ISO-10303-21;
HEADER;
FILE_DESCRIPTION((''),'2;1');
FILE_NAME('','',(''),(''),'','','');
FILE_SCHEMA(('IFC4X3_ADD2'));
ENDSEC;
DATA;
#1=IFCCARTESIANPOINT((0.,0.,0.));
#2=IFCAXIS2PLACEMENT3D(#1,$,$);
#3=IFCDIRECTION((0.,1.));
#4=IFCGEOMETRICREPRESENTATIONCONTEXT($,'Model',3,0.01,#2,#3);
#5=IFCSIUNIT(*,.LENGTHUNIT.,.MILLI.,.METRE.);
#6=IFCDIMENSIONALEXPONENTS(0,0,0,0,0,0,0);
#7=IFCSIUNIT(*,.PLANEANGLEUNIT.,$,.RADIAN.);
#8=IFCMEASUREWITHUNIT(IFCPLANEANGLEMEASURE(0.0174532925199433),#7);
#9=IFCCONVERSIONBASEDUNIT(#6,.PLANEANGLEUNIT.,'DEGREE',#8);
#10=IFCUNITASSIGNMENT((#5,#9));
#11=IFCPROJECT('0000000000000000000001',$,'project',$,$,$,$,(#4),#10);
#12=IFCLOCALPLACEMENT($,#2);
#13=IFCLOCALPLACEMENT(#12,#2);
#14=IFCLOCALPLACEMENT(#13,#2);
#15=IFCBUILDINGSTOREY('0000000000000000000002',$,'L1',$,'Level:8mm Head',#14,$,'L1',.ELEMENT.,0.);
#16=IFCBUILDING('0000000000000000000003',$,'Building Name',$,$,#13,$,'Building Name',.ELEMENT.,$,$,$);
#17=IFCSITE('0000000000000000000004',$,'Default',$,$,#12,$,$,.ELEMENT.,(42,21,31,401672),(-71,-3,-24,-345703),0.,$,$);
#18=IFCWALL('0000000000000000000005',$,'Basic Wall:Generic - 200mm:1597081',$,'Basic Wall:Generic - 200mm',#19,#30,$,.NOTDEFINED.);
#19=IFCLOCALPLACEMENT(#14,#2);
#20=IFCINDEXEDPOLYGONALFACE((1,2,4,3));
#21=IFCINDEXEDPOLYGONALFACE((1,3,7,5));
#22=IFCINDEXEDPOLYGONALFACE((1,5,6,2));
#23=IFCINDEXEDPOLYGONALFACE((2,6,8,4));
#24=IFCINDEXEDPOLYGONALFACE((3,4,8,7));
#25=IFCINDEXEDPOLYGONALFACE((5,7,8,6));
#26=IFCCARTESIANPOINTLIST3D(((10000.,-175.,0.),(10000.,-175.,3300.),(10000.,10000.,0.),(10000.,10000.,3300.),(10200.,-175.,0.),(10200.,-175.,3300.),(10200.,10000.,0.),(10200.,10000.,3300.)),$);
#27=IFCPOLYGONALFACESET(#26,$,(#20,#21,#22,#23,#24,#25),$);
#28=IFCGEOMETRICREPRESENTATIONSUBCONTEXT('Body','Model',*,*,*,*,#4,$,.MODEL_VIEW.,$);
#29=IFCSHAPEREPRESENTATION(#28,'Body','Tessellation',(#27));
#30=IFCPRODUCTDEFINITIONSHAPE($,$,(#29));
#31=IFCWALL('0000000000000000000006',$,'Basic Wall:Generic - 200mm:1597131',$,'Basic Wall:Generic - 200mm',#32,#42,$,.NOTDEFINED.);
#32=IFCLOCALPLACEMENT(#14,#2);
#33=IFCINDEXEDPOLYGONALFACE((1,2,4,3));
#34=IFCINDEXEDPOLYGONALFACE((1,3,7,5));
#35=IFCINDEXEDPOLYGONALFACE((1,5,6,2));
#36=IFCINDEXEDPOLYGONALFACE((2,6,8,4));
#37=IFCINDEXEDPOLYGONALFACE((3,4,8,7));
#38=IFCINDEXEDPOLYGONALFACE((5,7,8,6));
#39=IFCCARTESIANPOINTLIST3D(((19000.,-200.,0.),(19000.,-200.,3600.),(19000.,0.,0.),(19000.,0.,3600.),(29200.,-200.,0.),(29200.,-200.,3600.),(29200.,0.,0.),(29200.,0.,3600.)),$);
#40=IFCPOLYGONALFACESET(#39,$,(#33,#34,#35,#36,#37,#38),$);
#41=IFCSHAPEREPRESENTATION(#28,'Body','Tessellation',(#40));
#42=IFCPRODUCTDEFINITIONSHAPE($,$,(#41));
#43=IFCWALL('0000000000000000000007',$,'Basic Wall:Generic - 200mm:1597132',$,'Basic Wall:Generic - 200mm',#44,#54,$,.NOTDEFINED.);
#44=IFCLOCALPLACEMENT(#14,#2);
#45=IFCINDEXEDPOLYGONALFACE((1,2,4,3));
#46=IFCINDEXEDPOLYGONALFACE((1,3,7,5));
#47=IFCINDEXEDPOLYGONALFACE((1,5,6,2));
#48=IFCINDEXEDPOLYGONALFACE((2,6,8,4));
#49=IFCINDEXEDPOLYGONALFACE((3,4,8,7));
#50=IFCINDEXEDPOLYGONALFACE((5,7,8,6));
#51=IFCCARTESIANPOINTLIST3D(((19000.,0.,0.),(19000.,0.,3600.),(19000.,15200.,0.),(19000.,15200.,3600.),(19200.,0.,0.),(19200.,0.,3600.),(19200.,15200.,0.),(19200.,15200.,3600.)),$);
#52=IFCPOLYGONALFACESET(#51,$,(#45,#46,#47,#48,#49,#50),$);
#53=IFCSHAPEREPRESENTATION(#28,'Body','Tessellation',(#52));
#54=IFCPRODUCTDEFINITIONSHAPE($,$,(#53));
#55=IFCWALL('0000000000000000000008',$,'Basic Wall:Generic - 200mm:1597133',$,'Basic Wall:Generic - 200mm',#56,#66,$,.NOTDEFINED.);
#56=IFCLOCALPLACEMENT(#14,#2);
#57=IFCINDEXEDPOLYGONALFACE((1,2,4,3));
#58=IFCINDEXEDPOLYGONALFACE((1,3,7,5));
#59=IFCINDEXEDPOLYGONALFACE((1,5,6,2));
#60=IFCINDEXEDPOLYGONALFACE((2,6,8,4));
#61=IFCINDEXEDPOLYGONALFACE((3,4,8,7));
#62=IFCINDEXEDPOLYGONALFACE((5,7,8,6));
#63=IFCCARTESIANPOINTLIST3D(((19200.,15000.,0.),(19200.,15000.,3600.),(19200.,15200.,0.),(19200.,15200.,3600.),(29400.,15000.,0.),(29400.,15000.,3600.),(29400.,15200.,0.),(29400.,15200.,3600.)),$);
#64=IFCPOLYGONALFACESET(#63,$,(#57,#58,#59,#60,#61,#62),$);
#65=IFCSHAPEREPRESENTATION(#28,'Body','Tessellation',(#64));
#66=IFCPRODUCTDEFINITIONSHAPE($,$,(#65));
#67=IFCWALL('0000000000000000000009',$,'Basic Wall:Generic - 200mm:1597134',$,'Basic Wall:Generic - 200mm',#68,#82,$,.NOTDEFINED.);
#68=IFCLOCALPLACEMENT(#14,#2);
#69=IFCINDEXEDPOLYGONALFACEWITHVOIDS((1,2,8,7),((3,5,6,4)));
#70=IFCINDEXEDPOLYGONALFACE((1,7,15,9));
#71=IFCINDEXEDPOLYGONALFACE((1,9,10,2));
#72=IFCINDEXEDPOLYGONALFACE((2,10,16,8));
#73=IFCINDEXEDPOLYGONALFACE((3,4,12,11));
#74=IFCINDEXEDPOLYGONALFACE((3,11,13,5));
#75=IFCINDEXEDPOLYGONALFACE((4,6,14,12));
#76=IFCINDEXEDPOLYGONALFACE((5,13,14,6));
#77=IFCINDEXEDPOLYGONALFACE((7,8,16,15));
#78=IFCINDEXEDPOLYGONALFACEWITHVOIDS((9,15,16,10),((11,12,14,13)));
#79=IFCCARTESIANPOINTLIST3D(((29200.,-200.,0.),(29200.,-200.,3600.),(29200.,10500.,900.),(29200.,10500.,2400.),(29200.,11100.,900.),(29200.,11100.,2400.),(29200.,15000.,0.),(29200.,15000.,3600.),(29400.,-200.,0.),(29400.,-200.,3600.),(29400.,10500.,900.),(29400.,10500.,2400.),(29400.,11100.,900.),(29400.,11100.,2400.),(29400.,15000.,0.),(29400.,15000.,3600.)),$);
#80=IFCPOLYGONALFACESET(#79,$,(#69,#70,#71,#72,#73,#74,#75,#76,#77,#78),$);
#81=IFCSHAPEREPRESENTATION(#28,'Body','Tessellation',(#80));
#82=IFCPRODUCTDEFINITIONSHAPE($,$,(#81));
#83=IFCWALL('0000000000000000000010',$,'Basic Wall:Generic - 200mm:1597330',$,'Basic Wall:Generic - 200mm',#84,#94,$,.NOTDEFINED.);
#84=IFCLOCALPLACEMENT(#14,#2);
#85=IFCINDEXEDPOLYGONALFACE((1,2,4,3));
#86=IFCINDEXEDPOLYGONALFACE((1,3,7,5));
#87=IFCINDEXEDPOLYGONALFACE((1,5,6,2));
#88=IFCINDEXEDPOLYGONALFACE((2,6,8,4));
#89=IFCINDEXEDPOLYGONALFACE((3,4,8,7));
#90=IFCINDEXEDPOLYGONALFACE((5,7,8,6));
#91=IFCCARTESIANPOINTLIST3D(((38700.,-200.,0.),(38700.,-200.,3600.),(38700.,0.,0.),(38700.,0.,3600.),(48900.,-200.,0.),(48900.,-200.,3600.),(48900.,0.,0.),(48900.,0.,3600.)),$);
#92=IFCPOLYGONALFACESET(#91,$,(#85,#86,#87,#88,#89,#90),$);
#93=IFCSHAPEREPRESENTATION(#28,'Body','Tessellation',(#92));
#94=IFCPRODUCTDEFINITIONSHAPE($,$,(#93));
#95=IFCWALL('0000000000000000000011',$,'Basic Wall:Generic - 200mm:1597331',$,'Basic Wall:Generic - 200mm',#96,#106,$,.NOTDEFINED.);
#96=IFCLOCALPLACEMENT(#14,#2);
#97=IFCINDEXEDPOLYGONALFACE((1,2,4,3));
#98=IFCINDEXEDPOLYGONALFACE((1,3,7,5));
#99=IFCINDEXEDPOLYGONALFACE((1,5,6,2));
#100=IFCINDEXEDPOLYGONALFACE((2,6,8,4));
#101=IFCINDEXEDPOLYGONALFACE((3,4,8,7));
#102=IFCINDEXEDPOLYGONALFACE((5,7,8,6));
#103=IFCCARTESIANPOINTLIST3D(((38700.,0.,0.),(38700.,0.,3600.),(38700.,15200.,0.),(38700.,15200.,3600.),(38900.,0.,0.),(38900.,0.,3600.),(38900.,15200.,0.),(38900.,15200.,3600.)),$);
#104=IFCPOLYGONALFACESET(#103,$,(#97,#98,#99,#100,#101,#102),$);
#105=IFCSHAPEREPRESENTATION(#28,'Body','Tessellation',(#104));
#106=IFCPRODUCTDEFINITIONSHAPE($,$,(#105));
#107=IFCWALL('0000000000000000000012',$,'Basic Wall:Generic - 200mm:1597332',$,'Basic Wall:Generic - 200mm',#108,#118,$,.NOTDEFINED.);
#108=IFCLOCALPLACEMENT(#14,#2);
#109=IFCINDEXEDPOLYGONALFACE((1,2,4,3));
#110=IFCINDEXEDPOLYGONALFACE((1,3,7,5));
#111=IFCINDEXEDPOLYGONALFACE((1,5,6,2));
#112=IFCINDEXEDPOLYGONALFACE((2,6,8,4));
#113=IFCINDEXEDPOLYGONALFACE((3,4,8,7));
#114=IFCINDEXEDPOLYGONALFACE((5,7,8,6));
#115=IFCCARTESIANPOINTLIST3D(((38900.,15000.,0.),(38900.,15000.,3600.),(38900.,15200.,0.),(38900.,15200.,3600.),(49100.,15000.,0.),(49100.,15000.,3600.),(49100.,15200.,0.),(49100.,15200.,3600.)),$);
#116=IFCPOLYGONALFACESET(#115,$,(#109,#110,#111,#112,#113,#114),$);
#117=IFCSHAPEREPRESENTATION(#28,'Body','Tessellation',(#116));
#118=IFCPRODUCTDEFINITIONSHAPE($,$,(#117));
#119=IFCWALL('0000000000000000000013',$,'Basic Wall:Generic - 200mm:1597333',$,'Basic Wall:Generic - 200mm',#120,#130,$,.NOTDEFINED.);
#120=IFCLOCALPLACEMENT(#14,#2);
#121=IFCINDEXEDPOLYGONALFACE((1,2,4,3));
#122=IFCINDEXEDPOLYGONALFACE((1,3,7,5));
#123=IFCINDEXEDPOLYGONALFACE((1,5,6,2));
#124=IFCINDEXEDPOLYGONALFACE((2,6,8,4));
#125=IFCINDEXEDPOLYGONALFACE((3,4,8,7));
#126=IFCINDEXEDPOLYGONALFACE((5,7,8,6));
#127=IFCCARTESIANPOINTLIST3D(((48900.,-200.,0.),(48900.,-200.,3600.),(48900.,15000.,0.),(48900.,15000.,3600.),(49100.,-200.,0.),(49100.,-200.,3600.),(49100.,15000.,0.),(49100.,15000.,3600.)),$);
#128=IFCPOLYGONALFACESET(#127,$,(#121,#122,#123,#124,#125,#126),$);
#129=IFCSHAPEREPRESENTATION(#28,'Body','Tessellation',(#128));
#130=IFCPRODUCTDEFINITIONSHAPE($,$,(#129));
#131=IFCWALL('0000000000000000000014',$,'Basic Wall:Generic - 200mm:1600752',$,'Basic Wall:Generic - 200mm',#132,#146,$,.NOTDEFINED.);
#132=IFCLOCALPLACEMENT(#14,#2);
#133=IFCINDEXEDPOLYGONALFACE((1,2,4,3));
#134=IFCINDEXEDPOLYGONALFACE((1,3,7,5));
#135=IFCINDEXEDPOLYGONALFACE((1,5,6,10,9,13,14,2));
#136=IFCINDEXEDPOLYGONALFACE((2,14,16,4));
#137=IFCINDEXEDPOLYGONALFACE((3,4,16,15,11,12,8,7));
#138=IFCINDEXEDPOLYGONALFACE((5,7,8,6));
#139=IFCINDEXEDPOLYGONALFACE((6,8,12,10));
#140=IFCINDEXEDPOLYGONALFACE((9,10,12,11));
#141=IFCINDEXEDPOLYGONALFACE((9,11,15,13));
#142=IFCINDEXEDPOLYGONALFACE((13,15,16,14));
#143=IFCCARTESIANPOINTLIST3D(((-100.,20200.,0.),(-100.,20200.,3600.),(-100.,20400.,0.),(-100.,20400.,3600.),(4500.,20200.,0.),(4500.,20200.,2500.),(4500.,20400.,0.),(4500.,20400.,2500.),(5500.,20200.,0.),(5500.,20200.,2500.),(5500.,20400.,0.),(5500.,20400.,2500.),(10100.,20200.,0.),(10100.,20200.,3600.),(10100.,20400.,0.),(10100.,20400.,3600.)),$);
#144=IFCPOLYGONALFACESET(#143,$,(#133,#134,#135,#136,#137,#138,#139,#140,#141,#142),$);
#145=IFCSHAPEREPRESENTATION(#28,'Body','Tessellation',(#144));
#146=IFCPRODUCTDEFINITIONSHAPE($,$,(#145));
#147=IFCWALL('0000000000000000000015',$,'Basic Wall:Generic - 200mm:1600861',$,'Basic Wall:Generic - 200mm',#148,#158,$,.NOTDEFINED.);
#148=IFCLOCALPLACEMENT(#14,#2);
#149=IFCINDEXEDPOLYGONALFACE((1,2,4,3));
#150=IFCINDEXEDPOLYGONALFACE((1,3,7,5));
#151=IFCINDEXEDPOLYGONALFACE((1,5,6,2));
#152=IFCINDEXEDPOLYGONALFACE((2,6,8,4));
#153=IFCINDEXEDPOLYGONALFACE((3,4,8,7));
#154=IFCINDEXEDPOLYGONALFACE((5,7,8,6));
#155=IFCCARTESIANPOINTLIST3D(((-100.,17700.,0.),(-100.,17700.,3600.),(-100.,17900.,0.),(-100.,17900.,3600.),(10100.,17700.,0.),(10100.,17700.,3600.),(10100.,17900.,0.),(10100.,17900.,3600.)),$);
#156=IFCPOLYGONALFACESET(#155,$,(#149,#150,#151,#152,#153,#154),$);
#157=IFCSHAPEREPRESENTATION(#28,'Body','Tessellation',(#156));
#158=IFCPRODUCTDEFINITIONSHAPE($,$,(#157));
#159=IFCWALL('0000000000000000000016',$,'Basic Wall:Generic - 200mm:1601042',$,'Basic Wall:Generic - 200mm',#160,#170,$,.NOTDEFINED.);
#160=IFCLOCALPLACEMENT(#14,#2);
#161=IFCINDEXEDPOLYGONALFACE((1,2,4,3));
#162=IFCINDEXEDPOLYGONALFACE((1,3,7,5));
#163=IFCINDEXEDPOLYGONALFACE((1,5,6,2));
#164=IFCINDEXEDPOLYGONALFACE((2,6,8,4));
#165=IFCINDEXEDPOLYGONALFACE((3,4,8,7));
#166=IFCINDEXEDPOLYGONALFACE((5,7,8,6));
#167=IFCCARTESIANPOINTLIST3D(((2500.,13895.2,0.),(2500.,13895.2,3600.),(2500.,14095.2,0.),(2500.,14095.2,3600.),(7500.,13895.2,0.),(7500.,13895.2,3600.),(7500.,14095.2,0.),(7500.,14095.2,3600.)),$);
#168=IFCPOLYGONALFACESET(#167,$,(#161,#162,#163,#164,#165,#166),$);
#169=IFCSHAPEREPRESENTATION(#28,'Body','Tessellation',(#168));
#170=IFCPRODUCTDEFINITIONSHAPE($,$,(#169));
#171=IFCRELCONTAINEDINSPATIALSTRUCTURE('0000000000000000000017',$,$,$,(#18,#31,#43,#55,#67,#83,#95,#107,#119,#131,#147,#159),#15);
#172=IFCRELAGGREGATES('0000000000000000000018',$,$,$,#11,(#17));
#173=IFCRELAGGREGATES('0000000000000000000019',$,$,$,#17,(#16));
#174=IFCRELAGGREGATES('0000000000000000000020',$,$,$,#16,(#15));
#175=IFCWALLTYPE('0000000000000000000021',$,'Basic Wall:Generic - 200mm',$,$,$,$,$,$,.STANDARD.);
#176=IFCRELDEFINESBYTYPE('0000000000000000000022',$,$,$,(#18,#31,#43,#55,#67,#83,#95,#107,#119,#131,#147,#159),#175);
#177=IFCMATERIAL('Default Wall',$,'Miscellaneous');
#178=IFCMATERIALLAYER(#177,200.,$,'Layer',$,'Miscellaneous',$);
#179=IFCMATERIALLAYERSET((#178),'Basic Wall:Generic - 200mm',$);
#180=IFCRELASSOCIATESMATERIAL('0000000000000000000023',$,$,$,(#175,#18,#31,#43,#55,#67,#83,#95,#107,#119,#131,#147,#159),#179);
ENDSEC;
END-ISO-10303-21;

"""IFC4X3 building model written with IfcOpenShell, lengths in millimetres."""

from ifc_helpers import new_model, entity, si_unit, converted_unit, direction, frame, frame_2d, origin, origin_2d_with_axis, place, context, subcontext, project, spatial, rectangle, extrude, material, layer, layer_set, type_object, element, save


model = new_model("IFC4X3")

# Units and contexts
model_context = context("Model", 3, precision=0.01, world=origin(), true_north=direction((0.0, 1.0)))
body_context = subcontext(model_context, "Body", "Model", "MODEL_VIEW")
ifc_project = project(units=[si_unit("LENGTHUNIT", "METRE", prefix="MILLI"), converted_unit("PLANEANGLEUNIT", "DEGREE", entity("IfcPlaneAngleMeasure", 0.0174532925199433), si_unit("PLANEANGLEUNIT", "RADIAN"), dimensions=[0, 0, 0, 0, 0, 0, 0])], contexts=[model_context])

# Site, building, storey
site_placement = place(None, origin())
site = spatial("IfcSite", under=ifc_project, at=site_placement, Name="Default", CompositionType="ELEMENT", RefLatitude=(42, 21, 31, 401672), RefLongitude=(-71, -3, -24, -345703), RefElevation=0.0)
building_placement = place(site_placement, origin())
building = spatial("IfcBuilding", under=site, at=building_placement, Name="Building Name", LongName="Building Name", CompositionType="ELEMENT")
storey_placement = place(building_placement, origin())
storey = spatial("IfcBuildingStorey", under=building, at=storey_placement, Name="L1", ObjectType="Level:8mm Head", LongName="L1", CompositionType="ELEMENT", Elevation=0.0)

# Shared definitions
ifc_material_1 = material(Name="Default Wall", Category="Miscellaneous")

# Walls
ifc_layer_1 = layer(ifc_material_1, 200.0, Name="Layer", Category="Miscellaneous")
ifc_layer_set_1 = layer_set([ifc_layer_1], Name="Basic Wall:Generic - 200mm")
wall_type_1 = type_object("IfcWallType", Name="Basic Wall:Generic - 200mm", PredefinedType="STANDARD", material=ifc_layer_set_1)
wall_1_placement = place(storey_placement, frame((10100.0, -175.0, 0.0), z_axis=(0.0, 0.0, 1.0), x_axis=(0.0, 1.0, 0.0)))
element("IfcWall", 1, at=wall_1_placement, inside=storey, type_object=wall_type_1, material=ifc_layer_set_1, Name="Basic Wall:Generic - 200mm:1597081", ObjectType="Basic Wall:Generic - 200mm", PredefinedType="NOTDEFINED", context=body_context, shape_type="SweptSolid", body=[
    extrude(rectangle(XDim=10175.0, YDim=200.0, at=frame_2d((5087.5, 0.0), x_axis=(-1.0, 0.0))), origin(), (0.0, 0.0, 1.0), 3300.0),
])
wall_2_placement = place(storey_placement, frame((19000.0, -100.0, 0.0)))
element("IfcWall", 2, at=wall_2_placement, inside=storey, type_object=wall_type_1, material=ifc_layer_set_1, Name="Basic Wall:Generic - 200mm:1597131", ObjectType="Basic Wall:Generic - 200mm", PredefinedType="NOTDEFINED", context=body_context, shape_type="SweptSolid", body=[
    extrude(rectangle(XDim=10200.0, YDim=200.0, at=frame_2d((5100.0, 0.0), x_axis=(-1.0, 0.0))), origin(), (0.0, 0.0, 1.0), 3600.0),
])
wall_3_placement = place(storey_placement, frame((19100.0, 15200.0, 0.0), z_axis=(0.0, 0.0, 1.0), x_axis=(0.0, -1.0, 0.0)))
element("IfcWall", 3, at=wall_3_placement, inside=storey, type_object=wall_type_1, material=ifc_layer_set_1, Name="Basic Wall:Generic - 200mm:1597132", ObjectType="Basic Wall:Generic - 200mm", PredefinedType="NOTDEFINED", context=body_context, shape_type="SweptSolid", body=[
    extrude(rectangle(XDim=15200.0, YDim=200.0, at=frame_2d((7600.0, 0.0), x_axis=(-1.0, 0.0))), origin(), (0.0, 0.0, 1.0), 3600.0),
])
wall_4_placement = place(storey_placement, frame((29400.0, 15100.0, 0.0), z_axis=(0.0, 0.0, 1.0), x_axis=(-1.0, 0.0, 0.0)))
element("IfcWall", 4, at=wall_4_placement, inside=storey, type_object=wall_type_1, material=ifc_layer_set_1, Name="Basic Wall:Generic - 200mm:1597133", ObjectType="Basic Wall:Generic - 200mm", PredefinedType="NOTDEFINED", context=body_context, shape_type="SweptSolid", body=[
    extrude(rectangle(XDim=10200.0, YDim=200.0, at=frame_2d((5100.0, 0.0), x_axis=(-1.0, 0.0))), origin(), (0.0, 0.0, 1.0), 3600.0),
])

# Wall, opening
wall_5_placement = place(storey_placement, frame((29300.0, -200.0, 0.0), z_axis=(0.0, 0.0, 1.0), x_axis=(0.0, 1.0, 0.0)))
wall_5 = element("IfcWall", 5, at=wall_5_placement, inside=storey, type_object=wall_type_1, material=ifc_layer_set_1, Name="Basic Wall:Generic - 200mm:1597134", ObjectType="Basic Wall:Generic - 200mm", PredefinedType="NOTDEFINED", context=body_context, shape_type="SweptSolid", body=[
    extrude(rectangle(XDim=15200.0, YDim=200.0, at=frame_2d((7600.0, 0.0), x_axis=(-1.0, 0.0))), origin(), (0.0, 0.0, 1.0), 3600.0),
])
opening_1_placement = place(wall_5_placement, frame((11300.0, 100.0, 900.0)))
element("IfcOpeningElement", 6, at=opening_1_placement, cuts=wall_5, PredefinedType="OPENING", context=body_context, shape_type="SweptSolid", body=[
    extrude(rectangle(XDim=1500.0, YDim=600.0, at=frame_2d((750.0, 300.0), x_axis=(-1.0, 0.0))), frame((0.0, 0.0, 0.0), z_axis=(0.0, -1.0, 0.0), x_axis=(0.0, 0.0, 1.0)), (0.0, 0.0, 1.0), 200.0),
])

# Walls
wall_6_placement = place(storey_placement, frame((38700.0, -100.0, 0.0)))
element("IfcWall", 7, at=wall_6_placement, inside=storey, type_object=wall_type_1, material=ifc_layer_set_1, Name="Basic Wall:Generic - 200mm:1597330", ObjectType="Basic Wall:Generic - 200mm", PredefinedType="NOTDEFINED", context=body_context, shape_type="SweptSolid", body=[
    extrude(rectangle(XDim=10200.0, YDim=200.0, at=frame_2d((5100.0, 0.0), x_axis=(-1.0, 0.0))), origin(), (0.0, 0.0, 1.0), 3600.0),
])
wall_7_placement = place(storey_placement, frame((38800.0, 15200.0, 0.0), z_axis=(0.0, 0.0, 1.0), x_axis=(0.0, -1.0, 0.0)))
element("IfcWall", 8, at=wall_7_placement, inside=storey, type_object=wall_type_1, material=ifc_layer_set_1, Name="Basic Wall:Generic - 200mm:1597331", ObjectType="Basic Wall:Generic - 200mm", PredefinedType="NOTDEFINED", context=body_context, shape_type="SweptSolid", body=[
    extrude(rectangle(XDim=15200.0, YDim=200.0, at=frame_2d((7600.0, 0.0), x_axis=(-1.0, 0.0))), origin(), (0.0, 0.0, 1.0), 3600.0),
])
wall_8_placement = place(storey_placement, frame((49100.0, 15100.0, 0.0), z_axis=(0.0, 0.0, 1.0), x_axis=(-1.0, 0.0, 0.0)))
element("IfcWall", 9, at=wall_8_placement, inside=storey, type_object=wall_type_1, material=ifc_layer_set_1, Name="Basic Wall:Generic - 200mm:1597332", ObjectType="Basic Wall:Generic - 200mm", PredefinedType="NOTDEFINED", context=body_context, shape_type="SweptSolid", body=[
    extrude(rectangle(XDim=10200.0, YDim=200.0, at=frame_2d((5100.0, 0.0), x_axis=(-1.0, 0.0))), origin(), (0.0, 0.0, 1.0), 3600.0),
])
wall_9_placement = place(storey_placement, frame((49000.0, -200.0, 0.0), z_axis=(0.0, 0.0, 1.0), x_axis=(0.0, 1.0, 0.0)))
element("IfcWall", 10, at=wall_9_placement, inside=storey, type_object=wall_type_1, material=ifc_layer_set_1, Name="Basic Wall:Generic - 200mm:1597333", ObjectType="Basic Wall:Generic - 200mm", PredefinedType="NOTDEFINED", context=body_context, shape_type="SweptSolid", body=[
    extrude(rectangle(XDim=15200.0, YDim=200.0, at=frame_2d((7600.0, 0.0), x_axis=(-1.0, 0.0))), origin(), (0.0, 0.0, 1.0), 3600.0),
])

# Wall, opening
wall_10_placement = place(storey_placement, frame((10100.0, 20300.0, 0.0), z_axis=(0.0, 0.0, 1.0), x_axis=(-1.0, 0.0, 0.0)))
wall_10 = element("IfcWall", 11, at=wall_10_placement, inside=storey, type_object=wall_type_1, material=ifc_layer_set_1, Name="Basic Wall:Generic - 200mm:1600752", ObjectType="Basic Wall:Generic - 200mm", PredefinedType="NOTDEFINED", context=body_context, shape_type="SweptSolid", body=[
    extrude(rectangle(XDim=10200.0, YDim=200.0, at=frame_2d((5100.0, 0.0), x_axis=(1.0, 0.0))), origin(), (0.0, 0.0, 1.0), 3600.0),
])
opening_2_placement = place(wall_10_placement, frame((5600.0, 100.0, 0.0)))
element("IfcOpeningElement", 12, at=opening_2_placement, cuts=wall_10, PredefinedType="OPENING", context=body_context, shape_type="SweptSolid", body=[
    extrude(rectangle(XDim=2500.0, YDim=1000.0, at=origin_2d_with_axis()), frame((-500.0, -200.0, 1250.0), z_axis=(0.0, 1.0, 0.0), x_axis=(0.0, 0.0, -1.0)), (0.0, 0.0, 1.0), 200.0),
])

# Walls
wall_11_placement = place(storey_placement, frame((10100.0, 17800.0, 0.0), z_axis=(0.0, 0.0, 1.0), x_axis=(-1.0, 0.0, 0.0)))
element("IfcWall", 13, at=wall_11_placement, inside=storey, type_object=wall_type_1, material=ifc_layer_set_1, Name="Basic Wall:Generic - 200mm:1600861", ObjectType="Basic Wall:Generic - 200mm", PredefinedType="NOTDEFINED", context=body_context, shape_type="SweptSolid", body=[
    extrude(rectangle(XDim=10200.0, YDim=200.0, at=frame_2d((5100.0, 0.0), x_axis=(-1.0, 0.0))), origin(), (0.0, 0.0, 1.0), 3600.0),
])
wall_12_placement = place(storey_placement, frame((7500.0, 13995.2, 0.0), z_axis=(0.0, 0.0, 1.0), x_axis=(-1.0, 0.0, 0.0)))
element("IfcWall", 14, at=wall_12_placement, inside=storey, type_object=wall_type_1, material=ifc_layer_set_1, Name="Basic Wall:Generic - 200mm:1601042", ObjectType="Basic Wall:Generic - 200mm", PredefinedType="NOTDEFINED", context=body_context, shape_type="SweptSolid", body=[
    extrude(rectangle(XDim=5000.0, YDim=200.0, at=frame_2d((2500.0, 0.0), x_axis=(-1.0, 0.0))), origin(), (0.0, 0.0, 1.0), 3600.0),
])

save(model, "model.ifc")
